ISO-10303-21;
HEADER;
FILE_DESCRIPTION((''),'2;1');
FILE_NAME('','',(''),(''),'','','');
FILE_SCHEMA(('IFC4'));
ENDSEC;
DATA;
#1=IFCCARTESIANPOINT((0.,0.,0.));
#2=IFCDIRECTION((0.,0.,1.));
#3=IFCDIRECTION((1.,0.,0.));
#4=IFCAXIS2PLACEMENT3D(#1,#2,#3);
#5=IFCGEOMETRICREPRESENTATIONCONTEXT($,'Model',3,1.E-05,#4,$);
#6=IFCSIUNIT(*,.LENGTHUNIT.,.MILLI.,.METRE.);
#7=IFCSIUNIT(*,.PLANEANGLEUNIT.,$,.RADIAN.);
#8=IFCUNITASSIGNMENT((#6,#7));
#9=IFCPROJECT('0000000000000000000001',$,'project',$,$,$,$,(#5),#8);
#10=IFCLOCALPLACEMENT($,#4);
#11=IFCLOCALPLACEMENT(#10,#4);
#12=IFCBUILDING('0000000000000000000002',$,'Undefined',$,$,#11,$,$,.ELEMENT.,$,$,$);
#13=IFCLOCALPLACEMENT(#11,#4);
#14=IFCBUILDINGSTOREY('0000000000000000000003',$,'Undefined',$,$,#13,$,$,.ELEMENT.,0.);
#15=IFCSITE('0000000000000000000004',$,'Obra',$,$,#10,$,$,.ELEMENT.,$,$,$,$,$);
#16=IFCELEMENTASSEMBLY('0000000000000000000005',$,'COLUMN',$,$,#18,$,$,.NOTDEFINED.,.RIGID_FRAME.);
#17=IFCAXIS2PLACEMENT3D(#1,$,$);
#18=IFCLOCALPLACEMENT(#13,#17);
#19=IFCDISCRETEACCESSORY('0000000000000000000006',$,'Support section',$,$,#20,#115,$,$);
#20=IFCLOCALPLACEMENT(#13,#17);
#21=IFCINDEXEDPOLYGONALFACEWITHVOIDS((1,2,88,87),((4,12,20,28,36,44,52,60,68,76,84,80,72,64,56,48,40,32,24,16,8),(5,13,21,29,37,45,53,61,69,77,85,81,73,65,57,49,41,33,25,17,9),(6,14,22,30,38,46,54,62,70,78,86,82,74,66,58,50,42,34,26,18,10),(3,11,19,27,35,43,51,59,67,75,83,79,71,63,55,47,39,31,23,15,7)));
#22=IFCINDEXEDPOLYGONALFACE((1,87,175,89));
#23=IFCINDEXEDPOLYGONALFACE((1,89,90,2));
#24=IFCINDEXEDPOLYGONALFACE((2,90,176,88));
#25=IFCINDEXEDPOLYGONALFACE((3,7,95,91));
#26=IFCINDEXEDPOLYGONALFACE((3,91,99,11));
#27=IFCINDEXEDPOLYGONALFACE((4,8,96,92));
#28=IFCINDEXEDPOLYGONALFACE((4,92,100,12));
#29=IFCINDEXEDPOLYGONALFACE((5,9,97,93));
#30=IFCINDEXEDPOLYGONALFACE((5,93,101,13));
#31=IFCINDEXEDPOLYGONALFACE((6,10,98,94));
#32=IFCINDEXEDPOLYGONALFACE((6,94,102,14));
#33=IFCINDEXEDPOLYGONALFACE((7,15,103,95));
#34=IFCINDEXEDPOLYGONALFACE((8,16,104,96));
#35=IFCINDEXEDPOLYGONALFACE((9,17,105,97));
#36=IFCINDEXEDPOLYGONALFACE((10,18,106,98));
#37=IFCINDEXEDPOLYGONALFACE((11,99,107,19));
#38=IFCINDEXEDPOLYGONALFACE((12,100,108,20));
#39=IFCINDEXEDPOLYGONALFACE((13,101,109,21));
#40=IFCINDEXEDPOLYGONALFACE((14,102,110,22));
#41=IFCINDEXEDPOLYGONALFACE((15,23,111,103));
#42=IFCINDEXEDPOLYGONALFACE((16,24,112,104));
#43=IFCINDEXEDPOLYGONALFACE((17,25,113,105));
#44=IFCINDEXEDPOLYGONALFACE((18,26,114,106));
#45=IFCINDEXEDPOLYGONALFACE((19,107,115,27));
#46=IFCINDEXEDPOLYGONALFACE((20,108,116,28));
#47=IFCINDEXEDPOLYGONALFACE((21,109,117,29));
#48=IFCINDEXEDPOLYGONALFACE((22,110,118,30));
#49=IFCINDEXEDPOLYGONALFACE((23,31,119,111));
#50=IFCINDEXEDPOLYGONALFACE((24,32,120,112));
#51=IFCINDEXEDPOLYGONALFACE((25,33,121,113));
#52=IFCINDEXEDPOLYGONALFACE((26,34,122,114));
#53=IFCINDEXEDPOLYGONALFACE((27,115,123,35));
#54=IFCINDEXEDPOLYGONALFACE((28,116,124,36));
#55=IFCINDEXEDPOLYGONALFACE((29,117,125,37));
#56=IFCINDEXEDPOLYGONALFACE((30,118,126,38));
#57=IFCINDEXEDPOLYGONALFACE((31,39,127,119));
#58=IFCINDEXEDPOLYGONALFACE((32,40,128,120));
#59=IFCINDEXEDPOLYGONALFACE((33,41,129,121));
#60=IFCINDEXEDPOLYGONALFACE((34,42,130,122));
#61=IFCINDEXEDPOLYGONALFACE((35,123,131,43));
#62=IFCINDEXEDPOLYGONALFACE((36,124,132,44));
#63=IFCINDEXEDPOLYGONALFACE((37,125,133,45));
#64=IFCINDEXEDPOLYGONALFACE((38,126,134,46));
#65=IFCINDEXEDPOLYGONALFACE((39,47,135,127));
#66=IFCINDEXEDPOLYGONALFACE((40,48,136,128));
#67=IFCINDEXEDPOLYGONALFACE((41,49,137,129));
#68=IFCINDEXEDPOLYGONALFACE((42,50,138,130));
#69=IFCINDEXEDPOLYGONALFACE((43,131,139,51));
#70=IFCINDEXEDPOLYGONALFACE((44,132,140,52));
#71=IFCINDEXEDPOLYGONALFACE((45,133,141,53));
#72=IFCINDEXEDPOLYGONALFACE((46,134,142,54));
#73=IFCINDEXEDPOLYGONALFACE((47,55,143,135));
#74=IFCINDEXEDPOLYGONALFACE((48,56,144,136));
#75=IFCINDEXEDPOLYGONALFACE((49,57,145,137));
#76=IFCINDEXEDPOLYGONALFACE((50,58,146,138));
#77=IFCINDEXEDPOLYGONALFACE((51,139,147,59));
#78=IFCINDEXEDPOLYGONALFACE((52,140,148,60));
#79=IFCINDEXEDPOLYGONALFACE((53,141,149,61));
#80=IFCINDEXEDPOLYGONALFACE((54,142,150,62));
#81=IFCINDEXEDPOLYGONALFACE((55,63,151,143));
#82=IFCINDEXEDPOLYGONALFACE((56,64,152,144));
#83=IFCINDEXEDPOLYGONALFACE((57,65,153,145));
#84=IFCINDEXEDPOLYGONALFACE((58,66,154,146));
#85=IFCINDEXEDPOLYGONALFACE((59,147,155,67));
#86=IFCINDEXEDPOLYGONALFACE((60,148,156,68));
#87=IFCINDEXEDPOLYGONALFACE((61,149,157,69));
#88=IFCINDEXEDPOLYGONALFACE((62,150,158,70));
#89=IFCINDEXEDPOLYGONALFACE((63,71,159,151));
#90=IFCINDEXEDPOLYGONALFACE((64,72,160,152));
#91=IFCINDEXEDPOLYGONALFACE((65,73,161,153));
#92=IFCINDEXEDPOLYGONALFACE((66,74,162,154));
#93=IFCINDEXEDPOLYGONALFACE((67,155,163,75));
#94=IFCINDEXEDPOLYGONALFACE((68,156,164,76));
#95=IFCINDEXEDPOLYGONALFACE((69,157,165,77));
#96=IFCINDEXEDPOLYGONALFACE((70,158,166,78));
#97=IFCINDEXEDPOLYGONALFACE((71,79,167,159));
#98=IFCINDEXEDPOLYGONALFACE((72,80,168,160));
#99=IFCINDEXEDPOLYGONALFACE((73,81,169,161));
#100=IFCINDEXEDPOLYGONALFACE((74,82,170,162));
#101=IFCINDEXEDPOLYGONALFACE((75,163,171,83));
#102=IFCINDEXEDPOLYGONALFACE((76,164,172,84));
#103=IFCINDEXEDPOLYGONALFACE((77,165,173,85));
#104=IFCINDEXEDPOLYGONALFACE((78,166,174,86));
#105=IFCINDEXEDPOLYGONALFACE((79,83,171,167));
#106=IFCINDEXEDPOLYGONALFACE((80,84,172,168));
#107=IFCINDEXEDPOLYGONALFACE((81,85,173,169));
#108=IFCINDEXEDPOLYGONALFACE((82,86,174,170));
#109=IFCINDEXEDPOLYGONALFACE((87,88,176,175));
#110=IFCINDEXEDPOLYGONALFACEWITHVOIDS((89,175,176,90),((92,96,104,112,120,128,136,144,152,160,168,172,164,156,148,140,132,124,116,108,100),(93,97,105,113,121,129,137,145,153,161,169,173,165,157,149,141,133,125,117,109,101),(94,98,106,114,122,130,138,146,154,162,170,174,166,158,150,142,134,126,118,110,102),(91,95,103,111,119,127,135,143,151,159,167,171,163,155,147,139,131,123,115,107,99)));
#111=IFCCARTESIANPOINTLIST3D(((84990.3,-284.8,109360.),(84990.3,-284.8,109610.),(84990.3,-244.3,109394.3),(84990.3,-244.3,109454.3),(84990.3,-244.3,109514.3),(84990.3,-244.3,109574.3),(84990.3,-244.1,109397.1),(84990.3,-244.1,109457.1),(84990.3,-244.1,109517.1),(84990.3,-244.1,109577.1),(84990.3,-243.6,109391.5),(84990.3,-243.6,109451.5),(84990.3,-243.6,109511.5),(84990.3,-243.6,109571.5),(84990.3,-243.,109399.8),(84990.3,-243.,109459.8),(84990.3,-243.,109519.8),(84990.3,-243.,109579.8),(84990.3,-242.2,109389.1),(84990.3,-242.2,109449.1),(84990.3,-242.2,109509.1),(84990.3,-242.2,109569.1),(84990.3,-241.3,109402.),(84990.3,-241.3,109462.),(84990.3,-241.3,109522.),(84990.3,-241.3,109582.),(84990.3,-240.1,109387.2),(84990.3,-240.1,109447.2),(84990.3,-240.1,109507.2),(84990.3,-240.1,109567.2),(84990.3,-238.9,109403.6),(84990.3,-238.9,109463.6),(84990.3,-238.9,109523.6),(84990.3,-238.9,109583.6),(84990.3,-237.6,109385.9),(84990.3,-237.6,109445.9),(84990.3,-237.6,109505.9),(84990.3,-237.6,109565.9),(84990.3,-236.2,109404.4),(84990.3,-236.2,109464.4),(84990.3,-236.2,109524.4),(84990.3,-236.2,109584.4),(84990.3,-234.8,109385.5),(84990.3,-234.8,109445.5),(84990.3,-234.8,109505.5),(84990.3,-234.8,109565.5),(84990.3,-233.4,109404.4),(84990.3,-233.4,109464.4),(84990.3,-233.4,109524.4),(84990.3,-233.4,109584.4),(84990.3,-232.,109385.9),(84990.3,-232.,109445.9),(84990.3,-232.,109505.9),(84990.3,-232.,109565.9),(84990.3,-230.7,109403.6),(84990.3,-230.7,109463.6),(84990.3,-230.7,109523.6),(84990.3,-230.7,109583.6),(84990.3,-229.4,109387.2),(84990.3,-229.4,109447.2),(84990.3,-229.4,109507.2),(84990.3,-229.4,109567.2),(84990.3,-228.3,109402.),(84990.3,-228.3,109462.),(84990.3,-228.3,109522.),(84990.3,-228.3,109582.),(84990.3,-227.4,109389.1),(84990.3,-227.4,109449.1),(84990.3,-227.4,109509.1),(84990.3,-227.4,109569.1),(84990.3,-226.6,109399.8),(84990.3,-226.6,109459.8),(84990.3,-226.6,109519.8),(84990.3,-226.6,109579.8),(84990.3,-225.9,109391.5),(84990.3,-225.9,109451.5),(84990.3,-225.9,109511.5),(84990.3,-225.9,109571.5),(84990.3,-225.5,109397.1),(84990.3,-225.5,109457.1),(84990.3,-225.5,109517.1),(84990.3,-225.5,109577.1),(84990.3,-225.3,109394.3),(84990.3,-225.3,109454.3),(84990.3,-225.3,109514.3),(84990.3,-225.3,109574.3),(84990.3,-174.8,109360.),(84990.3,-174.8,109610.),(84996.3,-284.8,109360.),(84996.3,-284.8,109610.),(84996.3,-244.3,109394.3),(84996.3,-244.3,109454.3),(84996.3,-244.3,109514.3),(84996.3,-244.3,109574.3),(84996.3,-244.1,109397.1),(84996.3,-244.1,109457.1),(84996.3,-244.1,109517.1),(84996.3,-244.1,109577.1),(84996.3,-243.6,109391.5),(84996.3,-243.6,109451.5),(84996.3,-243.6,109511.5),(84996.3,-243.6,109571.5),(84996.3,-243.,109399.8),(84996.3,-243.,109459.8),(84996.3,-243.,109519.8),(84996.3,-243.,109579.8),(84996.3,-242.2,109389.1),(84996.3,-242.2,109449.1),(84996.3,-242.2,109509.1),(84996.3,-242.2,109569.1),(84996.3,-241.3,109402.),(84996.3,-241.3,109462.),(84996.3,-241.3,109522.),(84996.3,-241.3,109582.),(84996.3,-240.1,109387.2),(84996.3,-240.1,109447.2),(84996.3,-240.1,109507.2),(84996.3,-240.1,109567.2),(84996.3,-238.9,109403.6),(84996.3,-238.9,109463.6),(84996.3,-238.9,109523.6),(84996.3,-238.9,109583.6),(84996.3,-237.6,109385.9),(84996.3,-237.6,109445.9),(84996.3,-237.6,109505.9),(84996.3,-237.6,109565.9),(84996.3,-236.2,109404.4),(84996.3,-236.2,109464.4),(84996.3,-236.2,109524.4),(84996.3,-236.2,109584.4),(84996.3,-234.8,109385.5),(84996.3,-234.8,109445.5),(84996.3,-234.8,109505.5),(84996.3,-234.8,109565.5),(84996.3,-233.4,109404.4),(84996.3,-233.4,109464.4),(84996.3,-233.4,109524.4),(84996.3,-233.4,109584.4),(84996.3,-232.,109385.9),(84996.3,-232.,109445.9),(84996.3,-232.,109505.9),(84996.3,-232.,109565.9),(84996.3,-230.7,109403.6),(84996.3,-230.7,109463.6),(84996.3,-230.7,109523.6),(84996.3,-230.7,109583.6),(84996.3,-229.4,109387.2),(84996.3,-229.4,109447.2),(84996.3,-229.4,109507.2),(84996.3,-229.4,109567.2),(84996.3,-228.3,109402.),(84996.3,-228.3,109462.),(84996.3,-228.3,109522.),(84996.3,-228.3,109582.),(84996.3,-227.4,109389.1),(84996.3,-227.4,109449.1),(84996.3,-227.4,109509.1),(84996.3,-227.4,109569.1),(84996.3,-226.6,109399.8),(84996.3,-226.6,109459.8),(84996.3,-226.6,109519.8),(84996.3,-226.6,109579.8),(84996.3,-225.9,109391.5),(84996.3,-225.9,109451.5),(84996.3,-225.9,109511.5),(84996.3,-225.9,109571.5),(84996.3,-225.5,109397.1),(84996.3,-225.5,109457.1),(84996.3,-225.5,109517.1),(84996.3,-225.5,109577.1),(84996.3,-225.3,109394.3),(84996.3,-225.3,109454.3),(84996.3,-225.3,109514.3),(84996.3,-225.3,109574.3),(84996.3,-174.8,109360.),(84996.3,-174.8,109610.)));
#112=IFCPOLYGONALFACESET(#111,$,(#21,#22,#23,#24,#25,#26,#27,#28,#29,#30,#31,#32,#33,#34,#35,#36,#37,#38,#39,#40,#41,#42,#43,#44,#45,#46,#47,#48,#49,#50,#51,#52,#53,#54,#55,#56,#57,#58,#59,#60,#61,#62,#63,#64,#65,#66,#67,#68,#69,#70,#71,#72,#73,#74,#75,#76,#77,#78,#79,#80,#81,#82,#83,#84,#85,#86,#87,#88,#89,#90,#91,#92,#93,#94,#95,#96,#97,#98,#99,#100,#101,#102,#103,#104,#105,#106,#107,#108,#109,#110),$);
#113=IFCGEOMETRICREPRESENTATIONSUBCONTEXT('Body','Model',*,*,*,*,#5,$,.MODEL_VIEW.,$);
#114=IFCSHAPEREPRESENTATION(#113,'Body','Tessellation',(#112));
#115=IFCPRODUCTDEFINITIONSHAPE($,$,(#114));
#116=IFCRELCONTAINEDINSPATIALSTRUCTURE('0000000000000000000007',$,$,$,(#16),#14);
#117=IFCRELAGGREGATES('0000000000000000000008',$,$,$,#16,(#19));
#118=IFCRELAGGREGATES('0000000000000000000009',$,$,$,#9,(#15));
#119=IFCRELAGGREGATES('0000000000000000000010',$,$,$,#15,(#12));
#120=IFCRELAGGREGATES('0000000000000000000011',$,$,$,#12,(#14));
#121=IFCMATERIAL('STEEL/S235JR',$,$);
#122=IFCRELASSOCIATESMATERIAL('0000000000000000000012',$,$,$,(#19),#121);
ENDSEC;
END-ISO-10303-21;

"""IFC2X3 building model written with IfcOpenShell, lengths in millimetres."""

from ifc_helpers import new_model, si_unit, frame, origin_with_axes, origin_2d_with_axis, place, context, subcontext, project, spatial, rectangle, circle, extrude, source, transform, mapped, material, element, aggregate, save


model = new_model("IFC2X3")

# Units and contexts
model_context = context("Model", 3, precision=1e-05, world=origin_with_axes())
body_context = subcontext(model_context, "Body", "Model", "MODEL_VIEW")
ifc_project = project(units=[si_unit("LENGTHUNIT", "METRE", prefix="MILLI"), si_unit("PLANEANGLEUNIT", "RADIAN")], contexts=[model_context])

# Site, building, storey
site_placement = place(None, origin_with_axes())
site = spatial("IfcSite", under=ifc_project, at=site_placement, Name="Obra", CompositionType="ELEMENT")
building_placement = place(site_placement, origin_with_axes())
building = spatial("IfcBuilding", under=site, at=building_placement, Name="Undefined", CompositionType="ELEMENT")
storey_placement = place(building_placement, origin_with_axes())
storey = spatial("IfcBuildingStorey", under=building, at=storey_placement, Name="Undefined", CompositionType="ELEMENT", Elevation=0.0)

# Element assembly, discrete accessory, opening
assembly_1_placement = place(storey_placement, origin_with_axes())
assembly_1 = element("IfcElementAssembly", 1, at=assembly_1_placement, inside=storey, Name="COLUMN", AssemblyPlace="NOTDEFINED", PredefinedType="RIGID_FRAME")
ifc_material_1 = material(Name="STEEL/S235JR")
shared_shape_1 = source(origin_with_axes(), body_context, "Body", "SweptSolid", [
    extrude(circle(Radius=9.5, at=origin_2d_with_axis()), frame((0.0, -9.8, 0.0), z_axis=(0.0, 1.0, 0.0), x_axis=(1.0, 0.0, 0.0)), (0.0, 0.0, 1.0), 6.2),
])
discrete_accessory_1_placement = place(assembly_1_placement, frame((84993.3, -229.8, 109360.0), z_axis=(0.0, 0.0, 1.0), x_axis=(0.0, 1.0, 0.0)))
discrete_accessory_1 = element("IfcDiscreteAccessory", 2, at=discrete_accessory_1_placement, material=ifc_material_1, Name="Support section", context=body_context, shape_type="SweptSolid", body=[
    extrude(rectangle(XDim=6.0, YDim=110.0, at=origin_2d_with_axis()), frame((0.0, 0.0, 250.0), z_axis=(0.0, 0.0, -1.0), x_axis=(0.0, 1.0, 0.0)), (0.0, 0.0, 1.0), 250.0),
])
opening_1_placement = place(assembly_1_placement, frame((85000.0, -184.8, 109650.0), z_axis=(0.0, -1.0, 0.0), x_axis=(0.0, 0.0, -1.0)))
element("IfcOpeningElement", 3, at=opening_1_placement, cuts=discrete_accessory_1, ObjectType="Opening", context=body_context, shape_type="MappedRepresentation", body=[
    mapped(shared_shape_1, transform((75.0, 0.0, 50.0))),
    mapped(shared_shape_1, transform((135.0, 0.0, 50.0))),
    mapped(shared_shape_1, transform((195.0, 0.0, 50.0))),
    mapped(shared_shape_1, transform((255.0, 0.0, 50.0))),
])
aggregate(assembly_1, [discrete_accessory_1])

save(model, "model.ifc")
